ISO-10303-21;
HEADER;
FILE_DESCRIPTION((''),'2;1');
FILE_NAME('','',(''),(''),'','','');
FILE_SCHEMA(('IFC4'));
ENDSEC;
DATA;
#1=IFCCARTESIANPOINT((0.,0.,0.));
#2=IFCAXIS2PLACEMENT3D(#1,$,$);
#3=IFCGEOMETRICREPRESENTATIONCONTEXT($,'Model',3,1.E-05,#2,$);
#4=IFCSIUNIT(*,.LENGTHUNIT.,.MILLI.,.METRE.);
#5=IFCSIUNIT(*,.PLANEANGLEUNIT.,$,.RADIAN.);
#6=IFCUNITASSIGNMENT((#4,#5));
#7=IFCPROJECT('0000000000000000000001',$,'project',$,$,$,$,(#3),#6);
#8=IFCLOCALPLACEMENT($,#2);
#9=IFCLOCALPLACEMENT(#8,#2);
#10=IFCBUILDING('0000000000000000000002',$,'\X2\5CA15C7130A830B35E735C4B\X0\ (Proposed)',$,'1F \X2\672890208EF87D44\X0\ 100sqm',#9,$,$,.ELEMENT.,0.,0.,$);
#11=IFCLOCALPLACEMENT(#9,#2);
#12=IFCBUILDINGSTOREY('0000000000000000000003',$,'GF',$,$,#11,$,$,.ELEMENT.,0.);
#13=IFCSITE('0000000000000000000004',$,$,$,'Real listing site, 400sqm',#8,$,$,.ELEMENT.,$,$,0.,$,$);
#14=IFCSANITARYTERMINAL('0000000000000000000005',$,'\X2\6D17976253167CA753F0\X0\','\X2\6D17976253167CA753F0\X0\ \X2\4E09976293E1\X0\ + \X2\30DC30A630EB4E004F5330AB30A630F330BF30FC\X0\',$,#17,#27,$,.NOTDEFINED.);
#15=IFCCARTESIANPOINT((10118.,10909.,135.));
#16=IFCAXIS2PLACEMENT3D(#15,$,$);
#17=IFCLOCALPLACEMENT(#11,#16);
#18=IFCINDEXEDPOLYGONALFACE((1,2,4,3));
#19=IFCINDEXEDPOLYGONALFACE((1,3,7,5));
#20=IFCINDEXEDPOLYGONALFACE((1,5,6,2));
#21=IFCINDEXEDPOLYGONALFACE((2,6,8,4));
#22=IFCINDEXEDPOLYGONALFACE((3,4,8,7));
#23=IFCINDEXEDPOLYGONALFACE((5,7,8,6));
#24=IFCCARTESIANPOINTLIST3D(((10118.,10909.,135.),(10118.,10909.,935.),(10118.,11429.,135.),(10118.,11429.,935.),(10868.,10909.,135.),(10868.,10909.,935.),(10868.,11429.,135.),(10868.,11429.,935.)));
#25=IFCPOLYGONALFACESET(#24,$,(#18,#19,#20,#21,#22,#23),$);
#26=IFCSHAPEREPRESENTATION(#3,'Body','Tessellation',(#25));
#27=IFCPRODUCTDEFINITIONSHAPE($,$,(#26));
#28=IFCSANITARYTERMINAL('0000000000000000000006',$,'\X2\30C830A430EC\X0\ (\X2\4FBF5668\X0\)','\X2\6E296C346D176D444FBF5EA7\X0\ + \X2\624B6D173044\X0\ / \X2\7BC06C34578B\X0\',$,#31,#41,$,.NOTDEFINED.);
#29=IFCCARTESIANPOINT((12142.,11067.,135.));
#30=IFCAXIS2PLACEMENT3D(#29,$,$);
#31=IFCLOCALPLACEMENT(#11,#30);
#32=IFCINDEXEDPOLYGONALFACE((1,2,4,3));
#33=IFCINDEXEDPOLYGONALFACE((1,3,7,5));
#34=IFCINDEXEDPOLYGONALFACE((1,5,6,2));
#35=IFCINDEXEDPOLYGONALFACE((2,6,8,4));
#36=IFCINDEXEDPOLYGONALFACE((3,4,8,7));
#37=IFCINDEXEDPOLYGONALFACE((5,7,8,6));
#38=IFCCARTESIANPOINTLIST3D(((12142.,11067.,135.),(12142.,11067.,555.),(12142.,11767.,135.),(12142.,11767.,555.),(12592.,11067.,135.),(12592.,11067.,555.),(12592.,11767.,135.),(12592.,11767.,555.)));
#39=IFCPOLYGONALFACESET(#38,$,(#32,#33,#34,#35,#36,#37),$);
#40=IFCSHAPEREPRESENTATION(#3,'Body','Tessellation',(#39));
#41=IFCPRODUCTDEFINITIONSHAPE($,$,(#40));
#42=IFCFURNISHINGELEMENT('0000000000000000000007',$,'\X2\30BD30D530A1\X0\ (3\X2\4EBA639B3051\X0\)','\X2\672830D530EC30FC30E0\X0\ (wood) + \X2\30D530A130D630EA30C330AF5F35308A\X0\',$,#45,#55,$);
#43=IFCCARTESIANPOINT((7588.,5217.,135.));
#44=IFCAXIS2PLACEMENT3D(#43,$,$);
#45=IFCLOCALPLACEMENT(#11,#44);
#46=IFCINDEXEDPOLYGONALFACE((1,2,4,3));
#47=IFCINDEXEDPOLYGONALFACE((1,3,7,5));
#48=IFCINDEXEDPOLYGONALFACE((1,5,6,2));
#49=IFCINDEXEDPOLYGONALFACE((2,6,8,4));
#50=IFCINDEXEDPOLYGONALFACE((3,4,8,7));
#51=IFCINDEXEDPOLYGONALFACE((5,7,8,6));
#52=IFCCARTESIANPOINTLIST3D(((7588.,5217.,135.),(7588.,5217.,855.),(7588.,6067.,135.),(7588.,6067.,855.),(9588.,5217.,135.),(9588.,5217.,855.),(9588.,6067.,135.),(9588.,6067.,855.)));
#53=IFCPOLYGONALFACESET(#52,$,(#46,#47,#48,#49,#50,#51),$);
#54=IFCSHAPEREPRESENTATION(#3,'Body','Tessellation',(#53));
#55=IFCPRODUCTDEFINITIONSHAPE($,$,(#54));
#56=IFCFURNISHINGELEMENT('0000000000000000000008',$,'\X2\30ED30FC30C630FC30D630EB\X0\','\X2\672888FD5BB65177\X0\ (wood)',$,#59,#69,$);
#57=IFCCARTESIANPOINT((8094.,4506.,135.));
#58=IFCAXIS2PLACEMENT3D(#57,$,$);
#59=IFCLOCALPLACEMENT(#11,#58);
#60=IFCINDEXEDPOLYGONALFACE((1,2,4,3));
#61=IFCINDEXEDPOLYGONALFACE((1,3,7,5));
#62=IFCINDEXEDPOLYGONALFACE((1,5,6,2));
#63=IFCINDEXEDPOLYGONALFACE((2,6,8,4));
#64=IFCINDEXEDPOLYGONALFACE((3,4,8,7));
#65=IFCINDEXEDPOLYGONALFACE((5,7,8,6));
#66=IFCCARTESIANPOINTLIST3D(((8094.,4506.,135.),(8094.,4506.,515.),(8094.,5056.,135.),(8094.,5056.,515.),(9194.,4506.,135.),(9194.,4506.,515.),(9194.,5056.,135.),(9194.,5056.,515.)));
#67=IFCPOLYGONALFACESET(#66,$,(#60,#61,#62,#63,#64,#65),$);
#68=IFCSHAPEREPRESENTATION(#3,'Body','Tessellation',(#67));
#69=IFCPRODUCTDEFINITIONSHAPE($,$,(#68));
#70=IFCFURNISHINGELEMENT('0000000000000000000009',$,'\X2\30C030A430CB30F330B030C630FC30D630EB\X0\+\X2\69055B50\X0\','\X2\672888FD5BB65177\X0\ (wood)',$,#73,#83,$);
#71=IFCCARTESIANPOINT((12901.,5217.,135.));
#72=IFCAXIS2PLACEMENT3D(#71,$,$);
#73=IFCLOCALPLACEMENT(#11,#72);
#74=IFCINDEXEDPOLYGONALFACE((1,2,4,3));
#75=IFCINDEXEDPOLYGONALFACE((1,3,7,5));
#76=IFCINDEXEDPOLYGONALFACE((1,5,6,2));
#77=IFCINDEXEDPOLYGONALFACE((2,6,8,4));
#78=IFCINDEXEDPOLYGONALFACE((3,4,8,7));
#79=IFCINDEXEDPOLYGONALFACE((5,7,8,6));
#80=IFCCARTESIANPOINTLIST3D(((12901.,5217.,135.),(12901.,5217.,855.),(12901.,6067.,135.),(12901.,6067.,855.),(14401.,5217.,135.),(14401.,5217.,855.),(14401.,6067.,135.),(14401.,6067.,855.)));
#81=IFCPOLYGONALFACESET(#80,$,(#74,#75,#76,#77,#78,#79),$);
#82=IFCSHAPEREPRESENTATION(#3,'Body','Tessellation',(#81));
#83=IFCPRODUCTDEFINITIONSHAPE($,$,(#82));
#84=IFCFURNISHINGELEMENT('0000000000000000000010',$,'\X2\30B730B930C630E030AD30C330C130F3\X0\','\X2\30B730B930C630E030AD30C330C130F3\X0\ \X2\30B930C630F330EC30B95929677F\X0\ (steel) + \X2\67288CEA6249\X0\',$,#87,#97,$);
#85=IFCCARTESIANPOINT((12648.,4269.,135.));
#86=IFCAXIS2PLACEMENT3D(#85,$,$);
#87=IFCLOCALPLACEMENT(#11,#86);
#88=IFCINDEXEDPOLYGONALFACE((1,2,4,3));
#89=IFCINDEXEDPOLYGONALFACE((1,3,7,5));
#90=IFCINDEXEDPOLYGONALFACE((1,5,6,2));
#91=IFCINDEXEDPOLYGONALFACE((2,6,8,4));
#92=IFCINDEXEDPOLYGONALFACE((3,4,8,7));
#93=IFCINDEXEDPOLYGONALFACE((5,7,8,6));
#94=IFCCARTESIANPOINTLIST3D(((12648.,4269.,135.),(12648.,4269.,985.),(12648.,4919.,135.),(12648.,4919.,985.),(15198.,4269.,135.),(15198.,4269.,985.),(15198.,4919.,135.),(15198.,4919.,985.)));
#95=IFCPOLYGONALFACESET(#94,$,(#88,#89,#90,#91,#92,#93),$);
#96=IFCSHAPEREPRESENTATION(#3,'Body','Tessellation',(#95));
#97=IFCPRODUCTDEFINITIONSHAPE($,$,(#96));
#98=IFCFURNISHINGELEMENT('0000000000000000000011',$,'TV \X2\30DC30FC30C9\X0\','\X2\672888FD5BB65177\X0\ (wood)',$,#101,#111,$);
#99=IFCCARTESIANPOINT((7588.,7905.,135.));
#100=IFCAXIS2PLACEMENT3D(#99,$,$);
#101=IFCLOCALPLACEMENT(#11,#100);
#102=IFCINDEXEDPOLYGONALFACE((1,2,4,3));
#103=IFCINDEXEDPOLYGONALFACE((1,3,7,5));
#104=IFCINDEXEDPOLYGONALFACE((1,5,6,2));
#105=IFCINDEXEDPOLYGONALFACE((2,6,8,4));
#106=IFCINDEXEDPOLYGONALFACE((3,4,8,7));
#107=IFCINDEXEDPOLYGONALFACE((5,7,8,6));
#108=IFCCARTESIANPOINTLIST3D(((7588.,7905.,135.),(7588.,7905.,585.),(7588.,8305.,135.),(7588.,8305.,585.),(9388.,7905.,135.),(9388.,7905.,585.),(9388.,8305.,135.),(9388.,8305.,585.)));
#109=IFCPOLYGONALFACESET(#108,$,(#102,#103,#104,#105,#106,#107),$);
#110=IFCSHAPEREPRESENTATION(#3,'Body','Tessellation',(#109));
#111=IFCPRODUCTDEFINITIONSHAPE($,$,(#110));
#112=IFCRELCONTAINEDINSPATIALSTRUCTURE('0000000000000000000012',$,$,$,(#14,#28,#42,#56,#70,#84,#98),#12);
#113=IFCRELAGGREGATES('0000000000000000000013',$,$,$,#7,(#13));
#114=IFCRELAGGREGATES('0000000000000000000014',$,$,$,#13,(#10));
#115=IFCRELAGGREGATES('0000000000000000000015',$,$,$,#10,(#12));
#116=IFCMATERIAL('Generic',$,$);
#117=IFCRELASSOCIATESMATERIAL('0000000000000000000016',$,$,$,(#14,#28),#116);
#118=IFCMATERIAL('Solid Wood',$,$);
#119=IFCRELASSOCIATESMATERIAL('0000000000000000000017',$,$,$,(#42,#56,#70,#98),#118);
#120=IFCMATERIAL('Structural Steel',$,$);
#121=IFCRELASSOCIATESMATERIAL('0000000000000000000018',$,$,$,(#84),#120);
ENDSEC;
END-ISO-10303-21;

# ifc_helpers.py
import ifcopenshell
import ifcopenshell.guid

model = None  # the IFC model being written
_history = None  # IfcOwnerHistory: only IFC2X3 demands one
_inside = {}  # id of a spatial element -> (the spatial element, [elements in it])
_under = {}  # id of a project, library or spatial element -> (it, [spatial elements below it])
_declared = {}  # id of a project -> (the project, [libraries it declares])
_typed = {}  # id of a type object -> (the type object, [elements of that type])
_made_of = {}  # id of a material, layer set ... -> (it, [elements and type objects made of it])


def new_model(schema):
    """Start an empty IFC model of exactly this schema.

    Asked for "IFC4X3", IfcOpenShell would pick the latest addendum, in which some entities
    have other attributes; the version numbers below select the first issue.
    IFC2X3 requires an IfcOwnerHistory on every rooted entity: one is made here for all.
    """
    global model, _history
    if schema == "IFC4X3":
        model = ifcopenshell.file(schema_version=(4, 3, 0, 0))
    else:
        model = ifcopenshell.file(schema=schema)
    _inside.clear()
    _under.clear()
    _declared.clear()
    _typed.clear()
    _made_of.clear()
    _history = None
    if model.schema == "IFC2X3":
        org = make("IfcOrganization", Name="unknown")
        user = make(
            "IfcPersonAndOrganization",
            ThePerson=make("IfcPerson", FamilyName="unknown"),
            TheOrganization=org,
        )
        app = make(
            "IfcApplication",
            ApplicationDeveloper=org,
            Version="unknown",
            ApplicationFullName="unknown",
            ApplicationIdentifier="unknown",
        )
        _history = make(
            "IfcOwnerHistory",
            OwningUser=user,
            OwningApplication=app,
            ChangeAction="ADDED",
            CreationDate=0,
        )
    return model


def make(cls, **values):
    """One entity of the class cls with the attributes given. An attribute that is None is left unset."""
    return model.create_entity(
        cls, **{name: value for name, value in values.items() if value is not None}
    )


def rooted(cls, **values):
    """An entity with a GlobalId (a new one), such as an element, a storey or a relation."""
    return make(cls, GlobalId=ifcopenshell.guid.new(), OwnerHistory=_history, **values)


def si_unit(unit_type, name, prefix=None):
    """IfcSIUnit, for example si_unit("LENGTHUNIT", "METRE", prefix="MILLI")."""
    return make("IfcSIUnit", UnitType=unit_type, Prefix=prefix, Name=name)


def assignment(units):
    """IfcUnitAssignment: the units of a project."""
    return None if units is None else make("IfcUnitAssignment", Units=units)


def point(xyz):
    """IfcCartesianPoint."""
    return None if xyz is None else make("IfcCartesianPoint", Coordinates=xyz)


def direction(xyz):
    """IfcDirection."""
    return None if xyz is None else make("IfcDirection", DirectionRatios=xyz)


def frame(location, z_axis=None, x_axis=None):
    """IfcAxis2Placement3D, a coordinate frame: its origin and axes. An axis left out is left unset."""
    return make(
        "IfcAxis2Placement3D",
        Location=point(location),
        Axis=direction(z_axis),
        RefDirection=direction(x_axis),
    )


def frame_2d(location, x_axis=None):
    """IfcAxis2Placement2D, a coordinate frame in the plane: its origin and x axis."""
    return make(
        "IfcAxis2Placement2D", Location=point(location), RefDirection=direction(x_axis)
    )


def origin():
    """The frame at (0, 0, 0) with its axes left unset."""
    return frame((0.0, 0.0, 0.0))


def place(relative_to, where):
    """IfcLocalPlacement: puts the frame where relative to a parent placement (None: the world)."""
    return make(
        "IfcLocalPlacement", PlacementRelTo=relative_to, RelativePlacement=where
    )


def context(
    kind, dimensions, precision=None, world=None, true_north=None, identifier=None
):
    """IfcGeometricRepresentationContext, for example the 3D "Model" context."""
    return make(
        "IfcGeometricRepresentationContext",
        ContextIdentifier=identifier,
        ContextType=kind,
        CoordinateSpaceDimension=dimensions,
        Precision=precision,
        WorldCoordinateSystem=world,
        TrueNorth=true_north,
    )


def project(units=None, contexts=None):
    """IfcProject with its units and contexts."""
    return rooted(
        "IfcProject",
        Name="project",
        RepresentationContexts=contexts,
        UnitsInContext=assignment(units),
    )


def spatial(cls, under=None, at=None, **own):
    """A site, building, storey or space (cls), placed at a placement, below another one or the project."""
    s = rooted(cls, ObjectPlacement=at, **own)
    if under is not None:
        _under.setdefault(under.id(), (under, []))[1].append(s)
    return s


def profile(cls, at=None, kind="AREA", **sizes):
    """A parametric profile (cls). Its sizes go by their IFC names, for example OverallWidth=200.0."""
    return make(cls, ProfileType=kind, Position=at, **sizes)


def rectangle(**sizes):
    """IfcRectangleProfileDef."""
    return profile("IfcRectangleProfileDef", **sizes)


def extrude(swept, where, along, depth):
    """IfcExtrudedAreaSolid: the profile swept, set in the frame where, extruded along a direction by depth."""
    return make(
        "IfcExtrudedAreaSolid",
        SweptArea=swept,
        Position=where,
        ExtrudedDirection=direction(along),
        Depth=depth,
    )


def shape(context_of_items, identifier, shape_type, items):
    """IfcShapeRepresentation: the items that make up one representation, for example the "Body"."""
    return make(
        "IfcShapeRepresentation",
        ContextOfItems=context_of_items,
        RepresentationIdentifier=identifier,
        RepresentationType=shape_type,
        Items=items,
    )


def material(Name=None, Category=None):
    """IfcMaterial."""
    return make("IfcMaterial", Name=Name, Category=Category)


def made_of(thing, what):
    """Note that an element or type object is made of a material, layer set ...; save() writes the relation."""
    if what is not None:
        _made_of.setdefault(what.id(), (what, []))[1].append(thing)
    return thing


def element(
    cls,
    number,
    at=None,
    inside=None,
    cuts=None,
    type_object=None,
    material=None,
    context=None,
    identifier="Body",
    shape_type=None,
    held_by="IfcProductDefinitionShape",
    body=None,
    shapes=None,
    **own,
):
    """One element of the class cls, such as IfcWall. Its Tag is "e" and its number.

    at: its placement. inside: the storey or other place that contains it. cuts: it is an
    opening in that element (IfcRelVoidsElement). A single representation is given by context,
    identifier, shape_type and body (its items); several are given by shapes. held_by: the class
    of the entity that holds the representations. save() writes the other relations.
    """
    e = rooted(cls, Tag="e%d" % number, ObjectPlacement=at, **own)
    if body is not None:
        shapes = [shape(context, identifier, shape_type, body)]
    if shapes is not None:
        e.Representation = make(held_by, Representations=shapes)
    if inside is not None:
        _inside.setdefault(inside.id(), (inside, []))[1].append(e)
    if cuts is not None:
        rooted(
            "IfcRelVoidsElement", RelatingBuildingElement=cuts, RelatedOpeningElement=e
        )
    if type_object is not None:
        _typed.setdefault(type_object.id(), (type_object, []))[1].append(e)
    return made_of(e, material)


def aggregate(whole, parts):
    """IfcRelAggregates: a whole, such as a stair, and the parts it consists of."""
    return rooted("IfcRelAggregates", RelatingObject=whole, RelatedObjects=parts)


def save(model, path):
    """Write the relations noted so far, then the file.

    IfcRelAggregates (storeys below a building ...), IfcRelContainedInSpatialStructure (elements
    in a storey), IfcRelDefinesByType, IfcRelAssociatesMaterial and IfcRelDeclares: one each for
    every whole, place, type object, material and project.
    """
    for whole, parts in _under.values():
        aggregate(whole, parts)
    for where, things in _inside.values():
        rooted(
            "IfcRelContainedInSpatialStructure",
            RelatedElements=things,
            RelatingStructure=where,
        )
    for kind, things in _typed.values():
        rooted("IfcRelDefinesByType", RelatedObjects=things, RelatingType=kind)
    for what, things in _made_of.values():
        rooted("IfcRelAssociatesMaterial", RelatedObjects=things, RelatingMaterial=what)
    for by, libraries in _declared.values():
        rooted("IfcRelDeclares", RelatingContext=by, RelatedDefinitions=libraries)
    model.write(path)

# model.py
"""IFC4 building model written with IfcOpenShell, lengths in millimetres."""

from ifc_helpers import new_model, si_unit, frame, frame_2d, origin, place, context, project, spatial, rectangle, extrude, material, element, save


model = new_model("IFC4")

# Units and contexts
model_context = context("Model", 3, precision=1e-05, world=origin())
ifc_project = project(units=[si_unit("LENGTHUNIT", "METRE", prefix="MILLI"), si_unit("PLANEANGLEUNIT", "RADIAN")], contexts=[model_context])

# Site, building, storey
site_placement = place(None, origin())
site = spatial("IfcSite", under=ifc_project, at=site_placement, ObjectType="Real listing site, 400sqm", CompositionType="ELEMENT", RefElevation=0.0)
building_placement = place(site_placement, origin())
building = spatial("IfcBuilding", under=site, at=building_placement, Name="岡山エコ平屋 (Proposed)", ObjectType="1F 木造軸組 100sqm", CompositionType="ELEMENT", ElevationOfRefHeight=0.0, ElevationOfTerrain=0.0)
storey_placement = place(building_placement, origin())
storey = spatial("IfcBuildingStorey", under=building, at=storey_placement, Name="GF", CompositionType="ELEMENT", Elevation=0.0)

# Shared definitions
ifc_material_1 = material(Name="Solid Wood")

# Shared definitions
ifc_material_2 = material(Name="Structural Steel")

# Shared definitions
ifc_material_3 = material(Name="Generic")

# Sanitary terminals
sanitary_terminal_1_placement = place(storey_placement, frame((10118.0, 10909.0, 135.0)))
element("IfcSanitaryTerminal", 1, at=sanitary_terminal_1_placement, inside=storey, material=ifc_material_3, Name="洗面化粧台", Description="洗面化粧台 三面鏡 + ボウル一体カウンター", PredefinedType="NOTDEFINED", context=model_context, shape_type="SweptSolid", body=[
    extrude(rectangle(XDim=750.0, YDim=520.0, at=frame_2d((375.0, 260.0))), frame((10118.0, 10909.0, 135.0)), (0.0, 0.0, 1.0), 800.0),
])
sanitary_terminal_2_placement = place(storey_placement, frame((12142.0, 11067.0, 135.0)))
element("IfcSanitaryTerminal", 2, at=sanitary_terminal_2_placement, inside=storey, material=ifc_material_3, Name="トイレ (便器)", Description="温水洗浄便座 + 手洗い / 節水型", PredefinedType="NOTDEFINED", context=model_context, shape_type="SweptSolid", body=[
    extrude(rectangle(XDim=450.0, YDim=700.0, at=frame_2d((225.0, 350.0))), frame((12142.0, 11067.0, 135.0)), (0.0, 0.0, 1.0), 420.0),
])

# Furnishing elements
furnishing_1_placement = place(storey_placement, frame((7588.0, 5217.0, 135.0)))
element("IfcFurnishingElement", 3, at=furnishing_1_placement, inside=storey, material=ifc_material_1, Name="ソファ (3人掛け)", Description="木フレーム (wood) + ファブリック張り", context=model_context, shape_type="SweptSolid", body=[
    extrude(rectangle(XDim=2000.0, YDim=850.0, at=frame_2d((1000.0, 425.0))), frame((7588.0, 5217.0, 135.0)), (0.0, 0.0, 1.0), 720.0),
])
furnishing_2_placement = place(storey_placement, frame((8094.0, 4506.0, 135.0)))
element("IfcFurnishingElement", 4, at=furnishing_2_placement, inside=storey, material=ifc_material_1, Name="ローテーブル", Description="木製家具 (wood)", context=model_context, shape_type="SweptSolid", body=[
    extrude(rectangle(XDim=1100.0, YDim=550.0, at=frame_2d((550.0, 275.0))), frame((8094.0, 4506.0, 135.0)), (0.0, 0.0, 1.0), 380.0),
])
furnishing_3_placement = place(storey_placement, frame((12901.0, 5217.0, 135.0)))
element("IfcFurnishingElement", 5, at=furnishing_3_placement, inside=storey, material=ifc_material_1, Name="ダイニングテーブル+椅子", Description="木製家具 (wood)", context=model_context, shape_type="SweptSolid", body=[
    extrude(rectangle(XDim=1500.0, YDim=850.0, at=frame_2d((750.0, 425.0))), frame((12901.0, 5217.0, 135.0)), (0.0, 0.0, 1.0), 720.0),
])
furnishing_4_placement = place(storey_placement, frame((12648.0, 4269.0, 135.0)))
element("IfcFurnishingElement", 6, at=furnishing_4_placement, inside=storey, material=ifc_material_2, Name="システムキッチン", Description="システムキッチン ステンレス天板 (steel) + 木質扉", context=model_context, shape_type="SweptSolid", body=[
    extrude(rectangle(XDim=2550.0, YDim=650.0, at=frame_2d((1275.0, 325.0))), frame((12648.0, 4269.0, 135.0)), (0.0, 0.0, 1.0), 850.0),
])
furnishing_5_placement = place(storey_placement, frame((7588.0, 7905.0, 135.0)))
element("IfcFurnishingElement", 7, at=furnishing_5_placement, inside=storey, material=ifc_material_1, Name="TV ボード", Description="木製家具 (wood)", context=model_context, shape_type="SweptSolid", body=[
    extrude(rectangle(XDim=1800.0, YDim=400.0, at=frame_2d((900.0, 200.0))), frame((7588.0, 7905.0, 135.0)), (0.0, 0.0, 1.0), 450.0),
])

save(model, "model.ifc")
